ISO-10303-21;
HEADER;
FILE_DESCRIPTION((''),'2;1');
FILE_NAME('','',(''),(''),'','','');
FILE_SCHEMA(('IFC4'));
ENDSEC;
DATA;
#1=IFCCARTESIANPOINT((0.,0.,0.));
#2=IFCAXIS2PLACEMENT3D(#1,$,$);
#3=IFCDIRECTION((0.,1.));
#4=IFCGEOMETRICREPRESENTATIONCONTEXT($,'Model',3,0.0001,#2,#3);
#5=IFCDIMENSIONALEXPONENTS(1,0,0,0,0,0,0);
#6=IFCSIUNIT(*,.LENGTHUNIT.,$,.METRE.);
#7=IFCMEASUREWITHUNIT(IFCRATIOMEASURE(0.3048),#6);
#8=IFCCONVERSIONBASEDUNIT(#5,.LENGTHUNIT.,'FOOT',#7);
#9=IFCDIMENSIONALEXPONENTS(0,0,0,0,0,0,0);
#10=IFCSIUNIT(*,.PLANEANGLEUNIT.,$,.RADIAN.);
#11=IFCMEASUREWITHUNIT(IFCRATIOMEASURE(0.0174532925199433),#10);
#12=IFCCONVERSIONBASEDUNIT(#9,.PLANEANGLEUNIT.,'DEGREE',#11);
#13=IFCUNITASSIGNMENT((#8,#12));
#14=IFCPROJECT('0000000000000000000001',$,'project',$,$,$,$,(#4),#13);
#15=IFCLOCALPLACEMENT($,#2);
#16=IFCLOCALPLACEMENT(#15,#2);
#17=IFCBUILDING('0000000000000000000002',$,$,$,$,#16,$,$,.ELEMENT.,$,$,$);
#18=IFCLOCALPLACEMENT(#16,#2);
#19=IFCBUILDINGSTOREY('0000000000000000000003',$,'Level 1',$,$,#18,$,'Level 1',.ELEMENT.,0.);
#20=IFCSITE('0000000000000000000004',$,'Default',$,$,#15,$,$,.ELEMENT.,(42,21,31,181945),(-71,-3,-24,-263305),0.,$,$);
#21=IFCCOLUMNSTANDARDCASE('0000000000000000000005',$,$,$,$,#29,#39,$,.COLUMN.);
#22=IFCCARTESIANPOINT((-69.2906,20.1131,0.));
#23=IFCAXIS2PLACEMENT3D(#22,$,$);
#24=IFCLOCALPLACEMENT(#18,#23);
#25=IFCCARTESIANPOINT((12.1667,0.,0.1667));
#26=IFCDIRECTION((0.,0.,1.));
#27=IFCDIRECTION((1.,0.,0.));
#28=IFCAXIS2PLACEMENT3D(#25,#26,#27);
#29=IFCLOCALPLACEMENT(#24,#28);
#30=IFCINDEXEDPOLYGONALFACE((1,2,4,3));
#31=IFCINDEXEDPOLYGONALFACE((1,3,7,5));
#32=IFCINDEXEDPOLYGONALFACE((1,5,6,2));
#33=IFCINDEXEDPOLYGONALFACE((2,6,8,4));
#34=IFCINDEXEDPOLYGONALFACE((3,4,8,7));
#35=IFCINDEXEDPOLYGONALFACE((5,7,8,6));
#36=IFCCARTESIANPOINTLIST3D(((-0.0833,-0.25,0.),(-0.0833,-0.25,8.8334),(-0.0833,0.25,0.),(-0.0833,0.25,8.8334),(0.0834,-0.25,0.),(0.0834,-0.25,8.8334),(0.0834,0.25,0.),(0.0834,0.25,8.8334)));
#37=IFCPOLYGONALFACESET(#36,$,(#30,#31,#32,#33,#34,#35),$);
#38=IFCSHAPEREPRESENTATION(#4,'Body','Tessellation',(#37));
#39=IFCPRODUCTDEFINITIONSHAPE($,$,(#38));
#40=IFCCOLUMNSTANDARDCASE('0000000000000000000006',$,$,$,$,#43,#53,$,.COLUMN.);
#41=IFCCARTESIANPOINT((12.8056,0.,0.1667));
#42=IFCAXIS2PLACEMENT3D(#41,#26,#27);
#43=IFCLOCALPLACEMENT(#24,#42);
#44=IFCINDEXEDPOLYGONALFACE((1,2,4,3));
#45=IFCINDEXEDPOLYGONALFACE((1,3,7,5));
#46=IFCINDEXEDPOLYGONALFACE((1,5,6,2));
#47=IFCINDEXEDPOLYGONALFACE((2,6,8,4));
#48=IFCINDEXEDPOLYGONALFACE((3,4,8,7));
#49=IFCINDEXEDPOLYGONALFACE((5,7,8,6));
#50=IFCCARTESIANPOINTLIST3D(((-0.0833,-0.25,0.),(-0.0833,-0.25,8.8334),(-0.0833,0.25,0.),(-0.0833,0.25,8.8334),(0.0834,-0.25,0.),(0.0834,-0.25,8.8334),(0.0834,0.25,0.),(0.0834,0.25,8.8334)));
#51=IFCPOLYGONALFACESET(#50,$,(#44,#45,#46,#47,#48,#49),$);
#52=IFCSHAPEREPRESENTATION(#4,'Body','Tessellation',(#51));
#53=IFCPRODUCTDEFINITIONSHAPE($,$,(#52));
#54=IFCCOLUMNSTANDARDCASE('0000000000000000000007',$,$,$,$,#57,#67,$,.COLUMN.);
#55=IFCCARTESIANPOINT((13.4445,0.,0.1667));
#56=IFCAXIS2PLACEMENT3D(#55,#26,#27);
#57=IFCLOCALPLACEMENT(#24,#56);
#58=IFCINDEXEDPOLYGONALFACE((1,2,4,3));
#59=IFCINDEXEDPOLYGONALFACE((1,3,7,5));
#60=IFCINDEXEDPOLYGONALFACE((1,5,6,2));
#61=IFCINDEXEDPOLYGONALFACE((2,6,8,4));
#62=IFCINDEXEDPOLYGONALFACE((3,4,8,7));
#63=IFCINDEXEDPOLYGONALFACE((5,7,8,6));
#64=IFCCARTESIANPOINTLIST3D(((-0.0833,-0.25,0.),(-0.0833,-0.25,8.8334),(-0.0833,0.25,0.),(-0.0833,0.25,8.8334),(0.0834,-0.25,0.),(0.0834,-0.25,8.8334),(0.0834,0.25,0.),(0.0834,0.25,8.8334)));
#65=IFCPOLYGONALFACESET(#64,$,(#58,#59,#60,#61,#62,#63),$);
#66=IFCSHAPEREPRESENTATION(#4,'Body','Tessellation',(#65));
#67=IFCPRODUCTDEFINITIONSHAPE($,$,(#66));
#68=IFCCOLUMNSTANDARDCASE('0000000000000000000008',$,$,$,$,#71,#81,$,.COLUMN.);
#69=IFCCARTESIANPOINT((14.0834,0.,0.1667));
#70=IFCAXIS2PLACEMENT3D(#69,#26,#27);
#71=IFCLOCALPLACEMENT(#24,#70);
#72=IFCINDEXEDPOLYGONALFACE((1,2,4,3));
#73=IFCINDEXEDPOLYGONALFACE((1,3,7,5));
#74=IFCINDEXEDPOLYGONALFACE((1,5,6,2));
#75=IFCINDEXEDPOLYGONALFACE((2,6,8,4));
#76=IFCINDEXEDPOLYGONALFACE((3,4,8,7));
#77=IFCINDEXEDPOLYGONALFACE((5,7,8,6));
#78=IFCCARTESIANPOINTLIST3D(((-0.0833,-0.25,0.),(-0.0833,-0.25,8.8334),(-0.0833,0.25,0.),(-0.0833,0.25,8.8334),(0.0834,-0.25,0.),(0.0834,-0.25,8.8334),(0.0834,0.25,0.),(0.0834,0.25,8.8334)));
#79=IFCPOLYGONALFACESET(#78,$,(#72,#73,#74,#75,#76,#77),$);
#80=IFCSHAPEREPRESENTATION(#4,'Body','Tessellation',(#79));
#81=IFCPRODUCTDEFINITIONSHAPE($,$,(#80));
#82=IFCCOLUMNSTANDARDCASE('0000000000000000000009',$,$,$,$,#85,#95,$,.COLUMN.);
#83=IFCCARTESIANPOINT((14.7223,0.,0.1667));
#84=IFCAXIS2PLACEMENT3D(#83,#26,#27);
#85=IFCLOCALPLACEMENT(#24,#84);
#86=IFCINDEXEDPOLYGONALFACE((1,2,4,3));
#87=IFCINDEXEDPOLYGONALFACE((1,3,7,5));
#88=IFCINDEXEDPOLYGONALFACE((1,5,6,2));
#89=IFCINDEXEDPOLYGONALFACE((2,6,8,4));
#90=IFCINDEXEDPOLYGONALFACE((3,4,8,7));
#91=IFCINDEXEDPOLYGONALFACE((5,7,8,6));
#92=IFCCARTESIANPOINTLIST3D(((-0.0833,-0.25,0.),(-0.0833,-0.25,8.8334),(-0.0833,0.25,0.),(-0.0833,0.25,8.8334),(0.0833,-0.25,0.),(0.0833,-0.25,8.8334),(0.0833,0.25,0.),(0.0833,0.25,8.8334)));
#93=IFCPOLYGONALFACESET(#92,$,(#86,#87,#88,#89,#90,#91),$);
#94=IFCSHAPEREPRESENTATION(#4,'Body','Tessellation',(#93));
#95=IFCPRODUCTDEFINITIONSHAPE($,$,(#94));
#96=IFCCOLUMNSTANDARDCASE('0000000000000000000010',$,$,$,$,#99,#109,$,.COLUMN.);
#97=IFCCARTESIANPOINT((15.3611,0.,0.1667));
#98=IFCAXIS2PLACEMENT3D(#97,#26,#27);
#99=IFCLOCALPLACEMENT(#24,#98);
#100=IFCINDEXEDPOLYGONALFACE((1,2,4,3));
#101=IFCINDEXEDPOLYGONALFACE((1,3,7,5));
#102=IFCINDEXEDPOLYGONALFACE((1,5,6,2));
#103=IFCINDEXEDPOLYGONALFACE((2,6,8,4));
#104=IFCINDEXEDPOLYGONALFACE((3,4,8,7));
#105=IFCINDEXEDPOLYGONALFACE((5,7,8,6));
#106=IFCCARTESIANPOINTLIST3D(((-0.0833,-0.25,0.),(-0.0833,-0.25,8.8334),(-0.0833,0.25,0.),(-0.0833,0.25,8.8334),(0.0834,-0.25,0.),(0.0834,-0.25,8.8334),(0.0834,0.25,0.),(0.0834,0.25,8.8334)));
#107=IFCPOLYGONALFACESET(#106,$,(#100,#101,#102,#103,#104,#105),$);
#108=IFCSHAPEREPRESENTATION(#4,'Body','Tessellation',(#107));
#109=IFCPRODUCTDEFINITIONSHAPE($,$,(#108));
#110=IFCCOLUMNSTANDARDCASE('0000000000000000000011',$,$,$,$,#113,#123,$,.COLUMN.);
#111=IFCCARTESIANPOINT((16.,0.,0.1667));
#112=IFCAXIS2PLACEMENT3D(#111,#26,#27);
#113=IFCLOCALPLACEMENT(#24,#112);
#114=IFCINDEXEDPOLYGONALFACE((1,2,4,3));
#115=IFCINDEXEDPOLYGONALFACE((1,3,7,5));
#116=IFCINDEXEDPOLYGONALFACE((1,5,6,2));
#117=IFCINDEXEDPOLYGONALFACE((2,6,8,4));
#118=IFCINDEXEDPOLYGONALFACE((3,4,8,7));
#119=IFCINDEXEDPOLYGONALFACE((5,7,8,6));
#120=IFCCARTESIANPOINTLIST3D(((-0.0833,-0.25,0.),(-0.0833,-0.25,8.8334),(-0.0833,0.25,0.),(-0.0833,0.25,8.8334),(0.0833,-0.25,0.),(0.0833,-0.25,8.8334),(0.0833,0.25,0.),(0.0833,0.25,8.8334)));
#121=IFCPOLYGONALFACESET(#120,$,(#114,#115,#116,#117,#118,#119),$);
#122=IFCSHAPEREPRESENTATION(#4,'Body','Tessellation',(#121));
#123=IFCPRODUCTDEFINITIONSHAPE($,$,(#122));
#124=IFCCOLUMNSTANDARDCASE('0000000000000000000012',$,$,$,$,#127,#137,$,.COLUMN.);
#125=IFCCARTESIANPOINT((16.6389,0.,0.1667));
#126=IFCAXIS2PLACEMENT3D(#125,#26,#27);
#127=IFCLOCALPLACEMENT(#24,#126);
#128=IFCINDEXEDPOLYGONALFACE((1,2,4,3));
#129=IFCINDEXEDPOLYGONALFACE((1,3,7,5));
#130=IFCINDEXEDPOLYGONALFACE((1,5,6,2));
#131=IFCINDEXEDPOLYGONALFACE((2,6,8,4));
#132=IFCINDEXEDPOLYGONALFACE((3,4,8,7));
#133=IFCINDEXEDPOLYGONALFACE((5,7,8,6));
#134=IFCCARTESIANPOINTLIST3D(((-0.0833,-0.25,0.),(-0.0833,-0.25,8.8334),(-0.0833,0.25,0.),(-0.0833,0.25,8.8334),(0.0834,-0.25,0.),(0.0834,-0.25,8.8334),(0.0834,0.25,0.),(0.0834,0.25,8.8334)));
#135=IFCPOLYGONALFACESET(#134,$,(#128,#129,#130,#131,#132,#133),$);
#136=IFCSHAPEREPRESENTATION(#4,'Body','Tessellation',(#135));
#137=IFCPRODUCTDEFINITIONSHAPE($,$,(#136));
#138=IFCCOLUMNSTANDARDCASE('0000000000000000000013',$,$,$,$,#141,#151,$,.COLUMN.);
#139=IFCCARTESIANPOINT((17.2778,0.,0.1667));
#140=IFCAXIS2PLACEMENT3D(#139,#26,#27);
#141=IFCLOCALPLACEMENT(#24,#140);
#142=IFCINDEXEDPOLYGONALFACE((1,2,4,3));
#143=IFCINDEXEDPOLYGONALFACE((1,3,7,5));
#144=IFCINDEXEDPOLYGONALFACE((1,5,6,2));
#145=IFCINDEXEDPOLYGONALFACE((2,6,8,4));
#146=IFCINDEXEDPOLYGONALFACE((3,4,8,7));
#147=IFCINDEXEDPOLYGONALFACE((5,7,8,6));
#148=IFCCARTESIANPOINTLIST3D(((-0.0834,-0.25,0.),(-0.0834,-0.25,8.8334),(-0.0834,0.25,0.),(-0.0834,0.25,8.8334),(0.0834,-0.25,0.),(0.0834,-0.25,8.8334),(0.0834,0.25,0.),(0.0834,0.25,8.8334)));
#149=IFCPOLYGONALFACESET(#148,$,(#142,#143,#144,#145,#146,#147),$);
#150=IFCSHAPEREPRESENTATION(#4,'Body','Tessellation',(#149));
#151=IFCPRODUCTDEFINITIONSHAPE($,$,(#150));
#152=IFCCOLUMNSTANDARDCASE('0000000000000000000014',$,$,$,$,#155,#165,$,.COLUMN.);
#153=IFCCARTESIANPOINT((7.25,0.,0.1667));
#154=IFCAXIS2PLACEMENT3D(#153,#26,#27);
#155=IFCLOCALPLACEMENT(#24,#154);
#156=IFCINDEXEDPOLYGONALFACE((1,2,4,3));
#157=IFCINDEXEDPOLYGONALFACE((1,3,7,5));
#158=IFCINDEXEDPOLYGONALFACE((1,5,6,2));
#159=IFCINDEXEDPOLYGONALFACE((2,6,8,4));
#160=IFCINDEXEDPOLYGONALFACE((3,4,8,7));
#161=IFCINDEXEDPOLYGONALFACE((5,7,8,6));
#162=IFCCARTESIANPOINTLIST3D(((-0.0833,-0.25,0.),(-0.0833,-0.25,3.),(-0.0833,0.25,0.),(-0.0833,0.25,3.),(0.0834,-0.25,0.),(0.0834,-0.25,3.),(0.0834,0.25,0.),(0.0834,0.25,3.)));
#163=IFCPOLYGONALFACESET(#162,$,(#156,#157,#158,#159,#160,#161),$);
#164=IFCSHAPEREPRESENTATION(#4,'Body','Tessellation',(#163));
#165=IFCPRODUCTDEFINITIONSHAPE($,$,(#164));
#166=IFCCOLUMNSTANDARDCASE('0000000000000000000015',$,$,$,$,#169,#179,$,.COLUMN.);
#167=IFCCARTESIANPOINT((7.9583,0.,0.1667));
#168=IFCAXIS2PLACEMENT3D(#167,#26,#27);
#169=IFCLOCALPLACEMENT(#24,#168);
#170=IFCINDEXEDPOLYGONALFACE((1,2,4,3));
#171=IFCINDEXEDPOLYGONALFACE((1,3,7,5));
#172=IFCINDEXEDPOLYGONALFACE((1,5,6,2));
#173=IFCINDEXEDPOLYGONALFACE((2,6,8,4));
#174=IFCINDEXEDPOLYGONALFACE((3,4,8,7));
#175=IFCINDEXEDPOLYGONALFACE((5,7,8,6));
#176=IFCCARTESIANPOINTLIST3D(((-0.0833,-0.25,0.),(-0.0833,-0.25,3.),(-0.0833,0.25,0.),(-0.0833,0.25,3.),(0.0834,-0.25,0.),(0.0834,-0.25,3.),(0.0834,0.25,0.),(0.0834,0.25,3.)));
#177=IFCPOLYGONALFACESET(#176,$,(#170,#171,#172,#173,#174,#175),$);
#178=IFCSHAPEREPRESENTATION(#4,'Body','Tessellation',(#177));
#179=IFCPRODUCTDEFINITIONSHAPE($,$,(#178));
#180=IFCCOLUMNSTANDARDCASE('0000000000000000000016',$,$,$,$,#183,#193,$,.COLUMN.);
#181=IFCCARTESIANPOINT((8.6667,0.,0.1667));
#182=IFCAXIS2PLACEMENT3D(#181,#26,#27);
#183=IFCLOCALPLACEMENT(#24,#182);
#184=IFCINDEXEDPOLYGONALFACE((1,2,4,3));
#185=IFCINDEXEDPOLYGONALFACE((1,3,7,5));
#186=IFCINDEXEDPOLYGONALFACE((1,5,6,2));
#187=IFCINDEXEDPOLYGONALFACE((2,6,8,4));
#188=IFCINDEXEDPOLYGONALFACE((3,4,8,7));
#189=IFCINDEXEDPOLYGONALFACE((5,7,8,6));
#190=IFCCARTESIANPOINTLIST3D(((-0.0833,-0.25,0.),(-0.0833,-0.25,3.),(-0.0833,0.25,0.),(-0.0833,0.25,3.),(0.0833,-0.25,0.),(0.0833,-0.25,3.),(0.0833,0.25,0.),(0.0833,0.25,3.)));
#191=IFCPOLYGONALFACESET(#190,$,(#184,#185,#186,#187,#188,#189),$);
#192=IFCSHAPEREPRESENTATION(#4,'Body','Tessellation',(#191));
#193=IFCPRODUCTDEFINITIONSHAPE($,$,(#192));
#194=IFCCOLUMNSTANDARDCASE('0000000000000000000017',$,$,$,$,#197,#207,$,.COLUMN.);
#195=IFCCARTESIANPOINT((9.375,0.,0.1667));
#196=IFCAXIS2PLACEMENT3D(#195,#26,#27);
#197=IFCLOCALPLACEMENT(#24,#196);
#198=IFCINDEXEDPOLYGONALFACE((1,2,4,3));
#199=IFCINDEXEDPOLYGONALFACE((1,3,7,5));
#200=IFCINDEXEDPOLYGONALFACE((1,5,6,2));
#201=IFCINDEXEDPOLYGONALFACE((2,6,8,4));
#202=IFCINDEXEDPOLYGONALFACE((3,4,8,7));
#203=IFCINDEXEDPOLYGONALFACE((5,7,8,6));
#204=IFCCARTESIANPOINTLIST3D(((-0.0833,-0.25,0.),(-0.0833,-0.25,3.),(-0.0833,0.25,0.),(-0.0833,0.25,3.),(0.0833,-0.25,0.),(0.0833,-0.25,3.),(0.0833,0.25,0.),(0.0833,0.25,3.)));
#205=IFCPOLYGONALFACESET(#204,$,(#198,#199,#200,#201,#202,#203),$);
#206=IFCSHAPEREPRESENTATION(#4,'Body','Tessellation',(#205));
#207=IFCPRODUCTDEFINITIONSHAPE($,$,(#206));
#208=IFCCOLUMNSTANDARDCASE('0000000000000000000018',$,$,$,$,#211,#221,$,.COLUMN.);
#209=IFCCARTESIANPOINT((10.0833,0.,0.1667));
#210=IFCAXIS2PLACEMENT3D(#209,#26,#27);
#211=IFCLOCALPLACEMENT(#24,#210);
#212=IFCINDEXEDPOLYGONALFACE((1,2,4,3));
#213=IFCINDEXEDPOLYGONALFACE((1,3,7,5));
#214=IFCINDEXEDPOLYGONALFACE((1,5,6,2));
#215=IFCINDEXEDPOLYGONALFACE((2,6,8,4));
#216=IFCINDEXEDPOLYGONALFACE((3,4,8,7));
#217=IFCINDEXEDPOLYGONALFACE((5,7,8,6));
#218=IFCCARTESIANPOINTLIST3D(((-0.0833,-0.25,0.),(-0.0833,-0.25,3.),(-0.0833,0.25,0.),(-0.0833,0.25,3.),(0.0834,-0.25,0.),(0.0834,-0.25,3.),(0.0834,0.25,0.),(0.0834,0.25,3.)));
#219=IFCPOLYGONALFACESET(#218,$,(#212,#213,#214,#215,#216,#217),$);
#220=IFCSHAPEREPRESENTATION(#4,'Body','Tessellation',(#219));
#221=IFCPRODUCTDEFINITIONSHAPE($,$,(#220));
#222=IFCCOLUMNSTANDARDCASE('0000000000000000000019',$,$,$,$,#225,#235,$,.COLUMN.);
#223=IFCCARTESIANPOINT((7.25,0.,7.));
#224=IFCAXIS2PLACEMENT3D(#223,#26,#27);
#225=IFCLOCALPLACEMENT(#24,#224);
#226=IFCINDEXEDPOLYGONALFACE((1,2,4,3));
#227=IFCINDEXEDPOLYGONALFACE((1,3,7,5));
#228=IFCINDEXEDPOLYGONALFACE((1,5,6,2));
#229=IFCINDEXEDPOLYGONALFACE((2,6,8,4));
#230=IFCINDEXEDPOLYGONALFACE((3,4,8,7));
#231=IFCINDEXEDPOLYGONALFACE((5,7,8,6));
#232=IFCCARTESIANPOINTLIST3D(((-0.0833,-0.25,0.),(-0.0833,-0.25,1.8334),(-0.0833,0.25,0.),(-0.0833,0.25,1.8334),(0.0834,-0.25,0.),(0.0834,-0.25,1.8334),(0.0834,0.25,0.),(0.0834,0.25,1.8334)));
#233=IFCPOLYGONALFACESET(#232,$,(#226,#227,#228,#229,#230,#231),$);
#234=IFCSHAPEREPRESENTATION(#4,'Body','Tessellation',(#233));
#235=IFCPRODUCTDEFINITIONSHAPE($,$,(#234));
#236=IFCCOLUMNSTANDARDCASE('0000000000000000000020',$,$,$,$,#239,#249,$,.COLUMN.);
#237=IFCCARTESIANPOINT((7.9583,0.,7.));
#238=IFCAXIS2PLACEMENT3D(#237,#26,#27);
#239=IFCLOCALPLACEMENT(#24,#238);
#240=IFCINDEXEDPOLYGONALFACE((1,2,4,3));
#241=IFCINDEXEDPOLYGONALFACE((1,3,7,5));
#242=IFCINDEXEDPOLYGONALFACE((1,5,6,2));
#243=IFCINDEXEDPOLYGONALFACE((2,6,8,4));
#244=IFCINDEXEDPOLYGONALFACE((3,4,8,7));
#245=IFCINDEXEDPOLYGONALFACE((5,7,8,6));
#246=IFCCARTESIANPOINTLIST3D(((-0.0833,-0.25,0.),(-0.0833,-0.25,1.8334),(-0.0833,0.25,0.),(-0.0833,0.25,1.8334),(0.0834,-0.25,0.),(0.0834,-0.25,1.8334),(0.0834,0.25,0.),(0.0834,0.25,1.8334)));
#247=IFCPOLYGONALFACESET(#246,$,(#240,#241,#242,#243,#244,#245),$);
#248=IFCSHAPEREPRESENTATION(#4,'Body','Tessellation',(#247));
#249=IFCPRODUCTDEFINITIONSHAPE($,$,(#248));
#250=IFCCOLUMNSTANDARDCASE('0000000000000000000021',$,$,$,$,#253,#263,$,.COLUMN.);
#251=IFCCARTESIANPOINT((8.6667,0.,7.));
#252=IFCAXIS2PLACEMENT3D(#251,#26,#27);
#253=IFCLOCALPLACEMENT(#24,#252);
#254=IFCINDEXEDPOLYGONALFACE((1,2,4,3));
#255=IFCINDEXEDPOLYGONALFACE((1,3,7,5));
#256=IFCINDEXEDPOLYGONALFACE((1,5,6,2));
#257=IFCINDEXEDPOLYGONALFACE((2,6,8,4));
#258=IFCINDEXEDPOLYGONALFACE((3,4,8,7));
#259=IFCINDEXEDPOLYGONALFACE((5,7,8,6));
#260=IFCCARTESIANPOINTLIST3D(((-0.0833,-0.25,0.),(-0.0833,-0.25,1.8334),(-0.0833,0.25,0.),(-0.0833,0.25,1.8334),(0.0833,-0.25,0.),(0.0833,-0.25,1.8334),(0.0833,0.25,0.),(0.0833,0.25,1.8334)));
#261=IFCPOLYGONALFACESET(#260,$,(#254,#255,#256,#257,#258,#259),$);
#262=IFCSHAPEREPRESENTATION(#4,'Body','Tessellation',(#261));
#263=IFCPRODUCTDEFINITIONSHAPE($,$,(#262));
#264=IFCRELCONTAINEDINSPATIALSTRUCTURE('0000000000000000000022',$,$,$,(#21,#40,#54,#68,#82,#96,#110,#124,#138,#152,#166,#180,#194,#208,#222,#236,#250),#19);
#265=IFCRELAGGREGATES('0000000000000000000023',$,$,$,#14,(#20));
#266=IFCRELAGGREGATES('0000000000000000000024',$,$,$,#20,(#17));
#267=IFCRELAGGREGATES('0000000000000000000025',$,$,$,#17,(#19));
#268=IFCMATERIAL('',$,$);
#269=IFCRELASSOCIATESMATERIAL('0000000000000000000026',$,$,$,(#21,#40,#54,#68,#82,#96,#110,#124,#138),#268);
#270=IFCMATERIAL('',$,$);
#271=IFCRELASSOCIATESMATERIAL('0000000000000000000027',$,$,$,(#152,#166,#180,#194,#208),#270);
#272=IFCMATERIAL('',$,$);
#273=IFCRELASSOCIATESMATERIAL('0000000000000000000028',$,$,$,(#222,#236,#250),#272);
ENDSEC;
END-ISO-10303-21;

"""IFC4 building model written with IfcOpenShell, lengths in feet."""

from ifc_helpers import new_model, entity, si_unit, converted_unit, direction, frame, origin, place, context, project, spatial, rectangle, extrude, material, element, save


model = new_model("IFC4")

# Units and contexts
model_context = context("Model", 3, precision=0.0001, world=origin(), true_north=direction((0.0, 1.0)))
ifc_project = project(units=[converted_unit("LENGTHUNIT", "FOOT", entity("IfcRatioMeasure", 0.3048), si_unit("LENGTHUNIT", "METRE"), dimensions=[1, 0, 0, 0, 0, 0, 0]), converted_unit("PLANEANGLEUNIT", "DEGREE", entity("IfcRatioMeasure", 0.0174532925199433), si_unit("PLANEANGLEUNIT", "RADIAN"), dimensions=[0, 0, 0, 0, 0, 0, 0])], contexts=[model_context])

# Site, building, storey
site_placement = place(None, origin())
site = spatial("IfcSite", under=ifc_project, at=site_placement, Name="Default", CompositionType="ELEMENT", RefLatitude=(42, 21, 31, 181945), RefLongitude=(-71, -3, -24, -263305), RefElevation=0.0)
building_placement = place(site_placement, origin())
building = spatial("IfcBuilding", under=site, at=building_placement, CompositionType="ELEMENT")
storey_placement = place(building_placement, origin())
storey = spatial("IfcBuildingStorey", under=building, at=storey_placement, Name="Level 1", LongName="Level 1", CompositionType="ELEMENT", Elevation=0.0)

# Columns
ifc_material_1 = material(Name="")
placement_1 = place(storey_placement, frame((-69.2906, 20.1131, 0.0)))
for number, where, z_axis, x_axis in (
    (1, (12.1667, 0.0, 0.1667), (0.0, 0.0, 1.0), (1.0, 0.0, 0.0)),
    (2, (12.8056, 0.0, 0.1667), (0.0, 0.0, 1.0), (1.0, 0.0, 0.0)),
    (3, (13.4445, 0.0, 0.1667), (0.0, 0.0, 1.0), (1.0, 0.0, 0.0)),
    (4, (14.0834, 0.0, 0.1667), (0.0, 0.0, 1.0), (1.0, 0.0, 0.0)),
    (5, (14.7223, 0.0, 0.1667), (0.0, 0.0, 1.0), (1.0, 0.0, 0.0)),
    (6, (15.3611, 0.0, 0.1667), (0.0, 0.0, 1.0), (1.0, 0.0, 0.0)),
    (7, (16.0, 0.0, 0.1667), (0.0, 0.0, 1.0), (1.0, 0.0, 0.0)),
    (8, (16.6389, 0.0, 0.1667), (0.0, 0.0, 1.0), (1.0, 0.0, 0.0)),
    (9, (17.2778, 0.0, 0.1667), (0.0, 0.0, 1.0), (1.0, 0.0, 0.0)),
):
    element("IfcColumnStandardCase", number, at=place(placement_1, frame(where, z_axis=z_axis, x_axis=x_axis)), inside=storey, material=ifc_material_1, PredefinedType="COLUMN", context=model_context, shape_type="SweptSolid", body=[
        extrude(rectangle(XDim=0.1667, YDim=0.5), origin(), (0.0, 0.0, 1.0), 8.8334),
    ])
ifc_material_2 = material(Name="")
for number, where, z_axis, x_axis in (
    (10, (7.25, 0.0, 0.1667), (0.0, 0.0, 1.0), (1.0, 0.0, 0.0)),
    (11, (7.9583, 0.0, 0.1667), (0.0, 0.0, 1.0), (1.0, 0.0, 0.0)),
    (12, (8.6667, 0.0, 0.1667), (0.0, 0.0, 1.0), (1.0, 0.0, 0.0)),
    (13, (9.375, 0.0, 0.1667), (0.0, 0.0, 1.0), (1.0, 0.0, 0.0)),
    (14, (10.0833, 0.0, 0.1667), (0.0, 0.0, 1.0), (1.0, 0.0, 0.0)),
):
    element("IfcColumnStandardCase", number, at=place(placement_1, frame(where, z_axis=z_axis, x_axis=x_axis)), inside=storey, material=ifc_material_2, PredefinedType="COLUMN", context=model_context, shape_type="SweptSolid", body=[
        extrude(rectangle(XDim=0.1667, YDim=0.5), origin(), (0.0, 0.0, 1.0), 3.0),
    ])
ifc_material_3 = material(Name="")
for number, where, z_axis, x_axis in (
    (15, (7.25, 0.0, 7.0), (0.0, 0.0, 1.0), (1.0, 0.0, 0.0)),
    (16, (7.9583, 0.0, 7.0), (0.0, 0.0, 1.0), (1.0, 0.0, 0.0)),
    (17, (8.6667, 0.0, 7.0), (0.0, 0.0, 1.0), (1.0, 0.0, 0.0)),
):
    element("IfcColumnStandardCase", number, at=place(placement_1, frame(where, z_axis=z_axis, x_axis=x_axis)), inside=storey, material=ifc_material_3, PredefinedType="COLUMN", context=model_context, shape_type="SweptSolid", body=[
        extrude(rectangle(XDim=0.1667, YDim=0.5), origin(), (0.0, 0.0, 1.0), 1.8334),
    ])

save(model, "model.ifc")
